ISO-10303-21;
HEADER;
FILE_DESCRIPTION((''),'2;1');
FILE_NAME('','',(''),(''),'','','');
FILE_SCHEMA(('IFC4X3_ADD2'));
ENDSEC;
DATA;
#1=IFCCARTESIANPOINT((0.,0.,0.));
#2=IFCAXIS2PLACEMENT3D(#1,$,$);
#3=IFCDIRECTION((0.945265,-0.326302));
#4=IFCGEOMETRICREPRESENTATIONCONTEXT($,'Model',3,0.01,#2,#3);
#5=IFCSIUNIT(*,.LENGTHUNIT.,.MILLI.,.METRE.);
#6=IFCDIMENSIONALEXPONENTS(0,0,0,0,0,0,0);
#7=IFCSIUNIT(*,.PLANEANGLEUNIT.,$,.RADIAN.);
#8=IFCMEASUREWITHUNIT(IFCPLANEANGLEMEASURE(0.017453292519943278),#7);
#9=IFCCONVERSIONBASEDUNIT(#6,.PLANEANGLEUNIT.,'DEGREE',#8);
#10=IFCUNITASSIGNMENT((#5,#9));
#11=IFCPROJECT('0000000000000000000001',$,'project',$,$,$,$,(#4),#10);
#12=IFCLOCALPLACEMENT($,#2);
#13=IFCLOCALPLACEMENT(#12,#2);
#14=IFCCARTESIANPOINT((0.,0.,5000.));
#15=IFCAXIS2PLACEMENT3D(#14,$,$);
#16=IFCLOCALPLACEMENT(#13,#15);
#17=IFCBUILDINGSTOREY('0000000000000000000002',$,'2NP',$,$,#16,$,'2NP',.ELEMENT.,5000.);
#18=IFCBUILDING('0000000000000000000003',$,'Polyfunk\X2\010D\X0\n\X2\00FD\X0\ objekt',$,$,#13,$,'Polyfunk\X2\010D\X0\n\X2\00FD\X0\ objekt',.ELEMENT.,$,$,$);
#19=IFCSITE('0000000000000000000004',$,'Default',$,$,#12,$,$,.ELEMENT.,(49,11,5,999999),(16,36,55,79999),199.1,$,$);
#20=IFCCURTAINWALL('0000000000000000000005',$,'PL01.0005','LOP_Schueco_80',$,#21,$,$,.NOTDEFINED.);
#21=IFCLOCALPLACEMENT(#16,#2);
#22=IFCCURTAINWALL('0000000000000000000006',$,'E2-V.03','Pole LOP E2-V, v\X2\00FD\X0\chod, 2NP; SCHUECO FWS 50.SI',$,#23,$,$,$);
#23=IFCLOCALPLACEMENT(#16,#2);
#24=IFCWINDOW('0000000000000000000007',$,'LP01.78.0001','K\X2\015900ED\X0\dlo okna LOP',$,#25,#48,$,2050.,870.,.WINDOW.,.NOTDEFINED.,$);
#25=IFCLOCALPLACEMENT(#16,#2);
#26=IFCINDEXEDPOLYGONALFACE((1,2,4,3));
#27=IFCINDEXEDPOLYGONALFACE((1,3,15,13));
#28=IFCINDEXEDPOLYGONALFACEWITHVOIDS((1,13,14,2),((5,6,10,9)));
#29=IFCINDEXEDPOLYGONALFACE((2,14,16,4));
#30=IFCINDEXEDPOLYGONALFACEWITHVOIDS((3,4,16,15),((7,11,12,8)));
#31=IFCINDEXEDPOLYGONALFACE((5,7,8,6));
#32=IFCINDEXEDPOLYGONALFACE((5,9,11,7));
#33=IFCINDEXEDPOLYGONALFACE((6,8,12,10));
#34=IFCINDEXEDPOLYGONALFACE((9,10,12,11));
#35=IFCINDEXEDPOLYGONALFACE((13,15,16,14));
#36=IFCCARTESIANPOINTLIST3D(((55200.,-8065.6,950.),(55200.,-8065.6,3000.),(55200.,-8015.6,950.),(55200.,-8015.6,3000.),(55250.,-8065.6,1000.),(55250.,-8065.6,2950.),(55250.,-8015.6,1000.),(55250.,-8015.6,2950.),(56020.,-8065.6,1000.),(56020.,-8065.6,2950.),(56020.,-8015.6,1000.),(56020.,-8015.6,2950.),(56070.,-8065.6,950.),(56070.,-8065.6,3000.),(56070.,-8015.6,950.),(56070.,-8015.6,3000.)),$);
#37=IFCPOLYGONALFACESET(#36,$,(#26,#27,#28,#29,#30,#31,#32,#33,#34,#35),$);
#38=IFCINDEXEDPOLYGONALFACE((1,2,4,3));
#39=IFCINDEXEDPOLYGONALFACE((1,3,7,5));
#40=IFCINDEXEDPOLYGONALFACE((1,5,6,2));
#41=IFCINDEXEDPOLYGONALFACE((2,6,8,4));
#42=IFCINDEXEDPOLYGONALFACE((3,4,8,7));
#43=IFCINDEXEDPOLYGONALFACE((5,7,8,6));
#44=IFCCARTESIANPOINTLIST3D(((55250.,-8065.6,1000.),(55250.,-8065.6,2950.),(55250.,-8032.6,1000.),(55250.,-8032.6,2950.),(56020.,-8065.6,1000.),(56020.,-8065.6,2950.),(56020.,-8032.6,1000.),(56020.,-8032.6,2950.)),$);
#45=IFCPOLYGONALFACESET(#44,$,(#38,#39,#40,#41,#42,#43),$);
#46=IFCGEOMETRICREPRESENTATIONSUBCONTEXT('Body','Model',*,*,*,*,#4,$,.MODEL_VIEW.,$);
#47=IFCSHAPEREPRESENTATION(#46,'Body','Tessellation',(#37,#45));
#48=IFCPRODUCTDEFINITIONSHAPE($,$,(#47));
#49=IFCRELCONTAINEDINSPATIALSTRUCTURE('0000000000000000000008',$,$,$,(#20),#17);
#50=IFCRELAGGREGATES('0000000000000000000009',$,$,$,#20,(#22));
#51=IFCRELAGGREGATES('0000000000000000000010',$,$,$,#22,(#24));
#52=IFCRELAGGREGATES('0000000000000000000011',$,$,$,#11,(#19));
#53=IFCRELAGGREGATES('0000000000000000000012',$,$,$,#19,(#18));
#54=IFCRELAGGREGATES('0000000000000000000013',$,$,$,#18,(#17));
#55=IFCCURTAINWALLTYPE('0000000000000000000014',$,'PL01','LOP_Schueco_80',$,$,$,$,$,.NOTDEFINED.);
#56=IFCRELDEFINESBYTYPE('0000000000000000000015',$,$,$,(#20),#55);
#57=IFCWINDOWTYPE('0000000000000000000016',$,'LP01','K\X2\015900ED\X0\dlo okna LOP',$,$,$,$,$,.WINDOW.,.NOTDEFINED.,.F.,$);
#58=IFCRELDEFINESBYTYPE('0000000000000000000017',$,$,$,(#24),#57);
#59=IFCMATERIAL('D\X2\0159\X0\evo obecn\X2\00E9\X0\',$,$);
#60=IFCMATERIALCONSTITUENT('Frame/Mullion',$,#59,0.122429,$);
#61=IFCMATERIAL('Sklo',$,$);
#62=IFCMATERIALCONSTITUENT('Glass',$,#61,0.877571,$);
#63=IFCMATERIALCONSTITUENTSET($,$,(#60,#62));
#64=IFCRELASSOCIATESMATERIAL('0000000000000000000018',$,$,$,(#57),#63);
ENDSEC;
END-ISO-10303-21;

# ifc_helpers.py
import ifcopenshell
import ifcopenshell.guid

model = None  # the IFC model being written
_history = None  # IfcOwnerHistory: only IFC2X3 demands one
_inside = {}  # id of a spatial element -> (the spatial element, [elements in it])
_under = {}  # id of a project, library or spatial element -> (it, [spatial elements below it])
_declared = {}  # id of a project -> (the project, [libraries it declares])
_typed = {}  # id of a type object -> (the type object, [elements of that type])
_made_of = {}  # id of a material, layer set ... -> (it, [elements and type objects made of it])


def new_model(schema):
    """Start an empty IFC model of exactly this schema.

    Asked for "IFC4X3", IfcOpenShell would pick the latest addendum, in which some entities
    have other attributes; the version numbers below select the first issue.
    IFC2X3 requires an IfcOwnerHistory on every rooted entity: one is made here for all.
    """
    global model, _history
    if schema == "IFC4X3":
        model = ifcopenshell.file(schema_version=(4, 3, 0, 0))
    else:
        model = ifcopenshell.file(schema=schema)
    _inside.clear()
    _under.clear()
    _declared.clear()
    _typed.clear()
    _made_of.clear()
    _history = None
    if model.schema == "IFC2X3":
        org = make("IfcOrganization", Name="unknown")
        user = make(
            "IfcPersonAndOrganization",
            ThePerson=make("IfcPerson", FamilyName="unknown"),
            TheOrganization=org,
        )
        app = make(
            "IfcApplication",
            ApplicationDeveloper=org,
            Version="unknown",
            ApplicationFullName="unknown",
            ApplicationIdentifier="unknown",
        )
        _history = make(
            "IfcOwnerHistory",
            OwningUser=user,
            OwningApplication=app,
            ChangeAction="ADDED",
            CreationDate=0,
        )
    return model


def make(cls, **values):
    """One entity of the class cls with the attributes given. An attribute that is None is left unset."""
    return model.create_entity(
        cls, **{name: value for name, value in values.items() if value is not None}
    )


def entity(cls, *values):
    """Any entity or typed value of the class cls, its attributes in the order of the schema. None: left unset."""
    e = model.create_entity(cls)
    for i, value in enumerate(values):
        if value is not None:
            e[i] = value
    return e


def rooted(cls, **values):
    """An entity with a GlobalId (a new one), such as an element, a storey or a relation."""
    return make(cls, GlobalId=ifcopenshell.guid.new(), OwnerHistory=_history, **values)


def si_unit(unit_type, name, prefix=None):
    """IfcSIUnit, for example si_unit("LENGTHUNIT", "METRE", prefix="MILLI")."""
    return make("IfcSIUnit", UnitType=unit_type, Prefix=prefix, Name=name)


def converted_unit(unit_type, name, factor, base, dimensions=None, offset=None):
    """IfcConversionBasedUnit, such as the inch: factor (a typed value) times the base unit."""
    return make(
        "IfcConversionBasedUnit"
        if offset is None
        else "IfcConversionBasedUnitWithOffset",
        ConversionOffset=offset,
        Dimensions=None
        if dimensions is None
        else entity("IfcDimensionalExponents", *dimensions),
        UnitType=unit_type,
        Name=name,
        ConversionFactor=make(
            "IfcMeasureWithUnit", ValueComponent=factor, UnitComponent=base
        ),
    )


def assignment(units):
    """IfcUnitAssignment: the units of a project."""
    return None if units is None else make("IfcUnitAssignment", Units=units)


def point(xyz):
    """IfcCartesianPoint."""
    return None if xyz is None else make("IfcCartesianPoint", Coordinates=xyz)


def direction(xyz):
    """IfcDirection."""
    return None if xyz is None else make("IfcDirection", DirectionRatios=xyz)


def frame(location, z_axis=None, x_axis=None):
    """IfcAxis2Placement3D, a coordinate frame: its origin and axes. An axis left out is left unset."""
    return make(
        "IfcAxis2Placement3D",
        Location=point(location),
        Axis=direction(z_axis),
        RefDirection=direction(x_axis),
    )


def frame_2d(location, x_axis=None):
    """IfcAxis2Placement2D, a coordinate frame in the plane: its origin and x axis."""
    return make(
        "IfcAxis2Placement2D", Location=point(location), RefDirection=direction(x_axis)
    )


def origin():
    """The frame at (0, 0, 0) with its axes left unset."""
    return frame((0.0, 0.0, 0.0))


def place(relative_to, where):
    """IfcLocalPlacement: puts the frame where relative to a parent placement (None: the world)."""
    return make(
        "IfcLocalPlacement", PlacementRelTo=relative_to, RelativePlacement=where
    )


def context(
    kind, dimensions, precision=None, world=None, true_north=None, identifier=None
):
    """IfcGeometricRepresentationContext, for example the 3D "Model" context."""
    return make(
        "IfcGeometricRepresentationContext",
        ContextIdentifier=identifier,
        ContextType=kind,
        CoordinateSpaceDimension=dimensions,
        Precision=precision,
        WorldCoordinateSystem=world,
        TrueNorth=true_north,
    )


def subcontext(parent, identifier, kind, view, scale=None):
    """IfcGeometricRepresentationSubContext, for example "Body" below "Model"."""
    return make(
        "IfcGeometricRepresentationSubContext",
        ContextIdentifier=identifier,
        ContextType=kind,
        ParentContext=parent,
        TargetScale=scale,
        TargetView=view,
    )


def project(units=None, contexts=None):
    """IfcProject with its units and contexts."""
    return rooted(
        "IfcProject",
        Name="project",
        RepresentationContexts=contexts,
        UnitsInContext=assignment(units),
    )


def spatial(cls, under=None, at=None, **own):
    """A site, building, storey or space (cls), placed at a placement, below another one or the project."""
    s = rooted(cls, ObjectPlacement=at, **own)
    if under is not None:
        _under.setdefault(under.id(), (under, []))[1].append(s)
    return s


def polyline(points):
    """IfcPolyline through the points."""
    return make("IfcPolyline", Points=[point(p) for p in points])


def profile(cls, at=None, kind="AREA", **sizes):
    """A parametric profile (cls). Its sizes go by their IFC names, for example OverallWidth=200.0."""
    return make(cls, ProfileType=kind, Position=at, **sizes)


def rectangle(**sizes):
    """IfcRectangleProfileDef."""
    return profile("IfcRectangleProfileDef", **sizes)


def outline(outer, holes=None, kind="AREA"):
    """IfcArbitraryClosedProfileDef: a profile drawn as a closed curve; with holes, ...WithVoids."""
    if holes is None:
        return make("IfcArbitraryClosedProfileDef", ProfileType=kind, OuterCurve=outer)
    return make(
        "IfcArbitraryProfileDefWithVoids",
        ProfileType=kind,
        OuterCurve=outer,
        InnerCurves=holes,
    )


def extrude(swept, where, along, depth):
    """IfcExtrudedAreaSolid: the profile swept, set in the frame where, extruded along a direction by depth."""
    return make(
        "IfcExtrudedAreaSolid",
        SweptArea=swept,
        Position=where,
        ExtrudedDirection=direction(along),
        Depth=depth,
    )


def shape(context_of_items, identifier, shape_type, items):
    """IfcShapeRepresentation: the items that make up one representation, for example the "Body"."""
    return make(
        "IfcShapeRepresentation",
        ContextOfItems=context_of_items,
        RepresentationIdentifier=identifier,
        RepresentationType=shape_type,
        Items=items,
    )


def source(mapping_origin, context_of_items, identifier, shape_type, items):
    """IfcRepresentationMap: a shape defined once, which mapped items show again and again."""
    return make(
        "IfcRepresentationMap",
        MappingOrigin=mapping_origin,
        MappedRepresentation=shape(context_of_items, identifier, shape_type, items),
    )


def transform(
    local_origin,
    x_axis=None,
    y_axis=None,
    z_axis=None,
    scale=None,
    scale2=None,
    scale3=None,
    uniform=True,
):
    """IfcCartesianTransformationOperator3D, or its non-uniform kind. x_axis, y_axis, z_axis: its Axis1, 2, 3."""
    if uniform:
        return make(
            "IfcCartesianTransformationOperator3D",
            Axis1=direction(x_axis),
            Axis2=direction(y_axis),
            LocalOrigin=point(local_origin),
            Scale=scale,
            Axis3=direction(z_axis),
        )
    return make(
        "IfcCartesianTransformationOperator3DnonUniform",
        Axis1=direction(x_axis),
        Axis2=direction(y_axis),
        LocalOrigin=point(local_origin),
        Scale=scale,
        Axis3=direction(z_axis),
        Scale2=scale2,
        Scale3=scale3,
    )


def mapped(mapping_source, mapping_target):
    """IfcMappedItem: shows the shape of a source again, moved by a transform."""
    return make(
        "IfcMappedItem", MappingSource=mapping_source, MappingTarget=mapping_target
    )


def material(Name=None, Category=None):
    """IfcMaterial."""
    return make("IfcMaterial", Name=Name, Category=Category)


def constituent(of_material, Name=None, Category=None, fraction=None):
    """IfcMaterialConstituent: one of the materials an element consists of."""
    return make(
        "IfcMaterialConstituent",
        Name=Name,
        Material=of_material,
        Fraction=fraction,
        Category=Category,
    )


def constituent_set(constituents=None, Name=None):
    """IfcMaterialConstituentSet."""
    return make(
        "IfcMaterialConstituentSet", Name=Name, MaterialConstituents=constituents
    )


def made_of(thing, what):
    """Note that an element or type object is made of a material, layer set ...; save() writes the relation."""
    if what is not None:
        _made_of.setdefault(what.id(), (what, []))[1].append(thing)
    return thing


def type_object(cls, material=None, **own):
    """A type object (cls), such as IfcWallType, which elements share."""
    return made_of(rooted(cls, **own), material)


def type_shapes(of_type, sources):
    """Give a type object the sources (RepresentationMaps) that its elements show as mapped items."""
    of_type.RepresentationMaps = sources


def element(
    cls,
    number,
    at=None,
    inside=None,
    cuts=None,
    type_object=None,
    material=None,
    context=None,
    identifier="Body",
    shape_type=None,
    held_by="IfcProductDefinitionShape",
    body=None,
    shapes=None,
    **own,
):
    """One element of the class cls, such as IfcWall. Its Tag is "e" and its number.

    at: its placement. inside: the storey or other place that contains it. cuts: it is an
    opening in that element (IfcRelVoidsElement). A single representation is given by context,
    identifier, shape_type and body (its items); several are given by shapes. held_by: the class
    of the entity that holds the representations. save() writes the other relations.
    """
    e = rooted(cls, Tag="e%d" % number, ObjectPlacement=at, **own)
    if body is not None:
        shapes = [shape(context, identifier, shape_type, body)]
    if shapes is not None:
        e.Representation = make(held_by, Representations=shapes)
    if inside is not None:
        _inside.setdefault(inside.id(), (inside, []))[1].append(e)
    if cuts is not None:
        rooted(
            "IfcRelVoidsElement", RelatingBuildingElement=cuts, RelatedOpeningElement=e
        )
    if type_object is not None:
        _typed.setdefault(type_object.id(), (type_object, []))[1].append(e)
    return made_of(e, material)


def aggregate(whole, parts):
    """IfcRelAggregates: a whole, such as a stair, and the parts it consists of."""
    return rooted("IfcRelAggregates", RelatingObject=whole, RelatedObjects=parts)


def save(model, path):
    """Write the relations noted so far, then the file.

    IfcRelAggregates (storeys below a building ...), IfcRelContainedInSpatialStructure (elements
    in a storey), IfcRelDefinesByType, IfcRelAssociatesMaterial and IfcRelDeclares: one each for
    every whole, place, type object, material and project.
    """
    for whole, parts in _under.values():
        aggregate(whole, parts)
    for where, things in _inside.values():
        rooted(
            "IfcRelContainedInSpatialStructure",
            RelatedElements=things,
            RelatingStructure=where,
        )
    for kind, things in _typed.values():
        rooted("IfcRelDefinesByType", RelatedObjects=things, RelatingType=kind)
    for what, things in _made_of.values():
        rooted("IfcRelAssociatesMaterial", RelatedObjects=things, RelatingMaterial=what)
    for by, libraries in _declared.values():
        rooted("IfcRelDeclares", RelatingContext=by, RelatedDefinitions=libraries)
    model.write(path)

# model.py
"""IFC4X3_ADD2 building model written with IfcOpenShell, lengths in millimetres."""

from ifc_helpers import new_model, entity, si_unit, converted_unit, direction, frame, frame_2d, origin, place, context, subcontext, project, spatial, polyline, rectangle, outline, extrude, source, transform, mapped, material, constituent, constituent_set, type_object, type_shapes, element, aggregate, save


model = new_model("IFC4X3_ADD2")

# Units and contexts
model_context = context("Model", 3, precision=0.01, world=origin(), true_north=direction((0.945265, -0.326302)))
body_context = subcontext(model_context, "Body", "Model", "MODEL_VIEW")
ifc_project = project(units=[si_unit("LENGTHUNIT", "METRE", prefix="MILLI"), converted_unit("PLANEANGLEUNIT", "DEGREE", entity("IfcPlaneAngleMeasure", 0.017453292519943278), si_unit("PLANEANGLEUNIT", "RADIAN"), dimensions=[0, 0, 0, 0, 0, 0, 0])], contexts=[model_context])

# Site, building, storey
site_placement = place(None, origin())
site = spatial("IfcSite", under=ifc_project, at=site_placement, Name="Default", CompositionType="ELEMENT", RefLatitude=(49, 11, 5, 999999), RefLongitude=(16, 36, 55, 79999), RefElevation=199.1)
building_placement = place(site_placement, origin())
building = spatial("IfcBuilding", under=site, at=building_placement, Name="Polyfunkčný objekt", LongName="Polyfunkčný objekt", CompositionType="ELEMENT")
storey_placement = place(building_placement, frame((0.0, 0.0, 5000.0)))
storey = spatial("IfcBuildingStorey", under=building, at=storey_placement, Name="2NP", LongName="2NP", CompositionType="ELEMENT", Elevation=5000.0)

# Curtain walls
curtain_wall_type = type_object("IfcCurtainWallType", Name="PL01", Description="LOP_Schueco_80", PredefinedType="NOTDEFINED")
curtain_wall_1_placement = place(storey_placement, frame((0.0, 0.0, -5000.0)))
curtain_wall_1 = element("IfcCurtainWall", 1, at=curtain_wall_1_placement, inside=storey, type_object=curtain_wall_type, Name="PL01.0005", Description="LOP_Schueco_80", PredefinedType="NOTDEFINED")
curtain_wall_2 = element("IfcCurtainWall", 2, Name="E2-V.03", Description="Pole LOP E2-V, východ, 2NP; SCHUECO FWS 50.SI")
aggregate(curtain_wall_1, [curtain_wall_2])
ifc_material_1 = material(Name="Sklo")

# Window
ifc_material_2 = material(Name="Dřevo obecné")
ifc_constituent_1 = constituent(ifc_material_2, Name="Frame/Mullion", fraction=0.122429)
ifc_constituent_2 = constituent(ifc_material_1, Name="Glass", fraction=0.877571)
ifc_constituent_set = constituent_set(constituents=[ifc_constituent_1, ifc_constituent_2])
window_type = type_object("IfcWindowType", Name="LP01", Description="Křídlo okna LOP", ParameterTakesPrecedence=False, PartitioningType="NOTDEFINED", PredefinedType="WINDOW", material=ifc_constituent_set)
shared_shape_1 = source(origin(), body_context, "Body", "SweptSolid", [
    extrude(outline(polyline([(-1025.0, -435.0), (1025.0, -435.0), (1025.0, 435.0), (-1025.0, 435.0), (-1025.0, -435.0)]), holes=[polyline([(-975.0, -385.0), (-975.0, 385.0), (975.0, 385.0), (975.0, -385.0), (-975.0, -385.0)])]), frame((0.0, 50.0, 1025.0), z_axis=(0.0, -1.0, 0.0), x_axis=(0.0, 0.0, -1.0)), (0.0, 0.0, 1.0), 50.0),
    extrude(rectangle(XDim=770.0, YDim=33.0, at=frame_2d((0.0, 0.0), x_axis=(1.0, 0.0))), frame((0.0, 33.5, 50.0), z_axis=(0.0, 0.0, 1.0), x_axis=(-1.0, 0.0, 0.0)), (0.0, 0.0, 1.0), 1950.0),
])
type_shapes(window_type, [shared_shape_1])
window_placement = place(curtain_wall_1_placement, frame((55635.0, -8015.6, 5950.0), z_axis=(0.0, 0.0, 1.0), x_axis=(-1.0, 0.0, 0.0)))
window = element("IfcWindow", 3, at=window_placement, type_object=window_type, Name="LP01.78.0001", Description="Křídlo okna LOP", OverallHeight=2050.0, OverallWidth=870.0, PartitioningType="NOTDEFINED", PredefinedType="WINDOW", context=body_context, shape_type="MappedRepresentation", body=[
    mapped(shared_shape_1, transform((0.0, 0.0, 0.0), scale=1.0)),
])
aggregate(curtain_wall_2, [window])

save(model, "model.ifc")
